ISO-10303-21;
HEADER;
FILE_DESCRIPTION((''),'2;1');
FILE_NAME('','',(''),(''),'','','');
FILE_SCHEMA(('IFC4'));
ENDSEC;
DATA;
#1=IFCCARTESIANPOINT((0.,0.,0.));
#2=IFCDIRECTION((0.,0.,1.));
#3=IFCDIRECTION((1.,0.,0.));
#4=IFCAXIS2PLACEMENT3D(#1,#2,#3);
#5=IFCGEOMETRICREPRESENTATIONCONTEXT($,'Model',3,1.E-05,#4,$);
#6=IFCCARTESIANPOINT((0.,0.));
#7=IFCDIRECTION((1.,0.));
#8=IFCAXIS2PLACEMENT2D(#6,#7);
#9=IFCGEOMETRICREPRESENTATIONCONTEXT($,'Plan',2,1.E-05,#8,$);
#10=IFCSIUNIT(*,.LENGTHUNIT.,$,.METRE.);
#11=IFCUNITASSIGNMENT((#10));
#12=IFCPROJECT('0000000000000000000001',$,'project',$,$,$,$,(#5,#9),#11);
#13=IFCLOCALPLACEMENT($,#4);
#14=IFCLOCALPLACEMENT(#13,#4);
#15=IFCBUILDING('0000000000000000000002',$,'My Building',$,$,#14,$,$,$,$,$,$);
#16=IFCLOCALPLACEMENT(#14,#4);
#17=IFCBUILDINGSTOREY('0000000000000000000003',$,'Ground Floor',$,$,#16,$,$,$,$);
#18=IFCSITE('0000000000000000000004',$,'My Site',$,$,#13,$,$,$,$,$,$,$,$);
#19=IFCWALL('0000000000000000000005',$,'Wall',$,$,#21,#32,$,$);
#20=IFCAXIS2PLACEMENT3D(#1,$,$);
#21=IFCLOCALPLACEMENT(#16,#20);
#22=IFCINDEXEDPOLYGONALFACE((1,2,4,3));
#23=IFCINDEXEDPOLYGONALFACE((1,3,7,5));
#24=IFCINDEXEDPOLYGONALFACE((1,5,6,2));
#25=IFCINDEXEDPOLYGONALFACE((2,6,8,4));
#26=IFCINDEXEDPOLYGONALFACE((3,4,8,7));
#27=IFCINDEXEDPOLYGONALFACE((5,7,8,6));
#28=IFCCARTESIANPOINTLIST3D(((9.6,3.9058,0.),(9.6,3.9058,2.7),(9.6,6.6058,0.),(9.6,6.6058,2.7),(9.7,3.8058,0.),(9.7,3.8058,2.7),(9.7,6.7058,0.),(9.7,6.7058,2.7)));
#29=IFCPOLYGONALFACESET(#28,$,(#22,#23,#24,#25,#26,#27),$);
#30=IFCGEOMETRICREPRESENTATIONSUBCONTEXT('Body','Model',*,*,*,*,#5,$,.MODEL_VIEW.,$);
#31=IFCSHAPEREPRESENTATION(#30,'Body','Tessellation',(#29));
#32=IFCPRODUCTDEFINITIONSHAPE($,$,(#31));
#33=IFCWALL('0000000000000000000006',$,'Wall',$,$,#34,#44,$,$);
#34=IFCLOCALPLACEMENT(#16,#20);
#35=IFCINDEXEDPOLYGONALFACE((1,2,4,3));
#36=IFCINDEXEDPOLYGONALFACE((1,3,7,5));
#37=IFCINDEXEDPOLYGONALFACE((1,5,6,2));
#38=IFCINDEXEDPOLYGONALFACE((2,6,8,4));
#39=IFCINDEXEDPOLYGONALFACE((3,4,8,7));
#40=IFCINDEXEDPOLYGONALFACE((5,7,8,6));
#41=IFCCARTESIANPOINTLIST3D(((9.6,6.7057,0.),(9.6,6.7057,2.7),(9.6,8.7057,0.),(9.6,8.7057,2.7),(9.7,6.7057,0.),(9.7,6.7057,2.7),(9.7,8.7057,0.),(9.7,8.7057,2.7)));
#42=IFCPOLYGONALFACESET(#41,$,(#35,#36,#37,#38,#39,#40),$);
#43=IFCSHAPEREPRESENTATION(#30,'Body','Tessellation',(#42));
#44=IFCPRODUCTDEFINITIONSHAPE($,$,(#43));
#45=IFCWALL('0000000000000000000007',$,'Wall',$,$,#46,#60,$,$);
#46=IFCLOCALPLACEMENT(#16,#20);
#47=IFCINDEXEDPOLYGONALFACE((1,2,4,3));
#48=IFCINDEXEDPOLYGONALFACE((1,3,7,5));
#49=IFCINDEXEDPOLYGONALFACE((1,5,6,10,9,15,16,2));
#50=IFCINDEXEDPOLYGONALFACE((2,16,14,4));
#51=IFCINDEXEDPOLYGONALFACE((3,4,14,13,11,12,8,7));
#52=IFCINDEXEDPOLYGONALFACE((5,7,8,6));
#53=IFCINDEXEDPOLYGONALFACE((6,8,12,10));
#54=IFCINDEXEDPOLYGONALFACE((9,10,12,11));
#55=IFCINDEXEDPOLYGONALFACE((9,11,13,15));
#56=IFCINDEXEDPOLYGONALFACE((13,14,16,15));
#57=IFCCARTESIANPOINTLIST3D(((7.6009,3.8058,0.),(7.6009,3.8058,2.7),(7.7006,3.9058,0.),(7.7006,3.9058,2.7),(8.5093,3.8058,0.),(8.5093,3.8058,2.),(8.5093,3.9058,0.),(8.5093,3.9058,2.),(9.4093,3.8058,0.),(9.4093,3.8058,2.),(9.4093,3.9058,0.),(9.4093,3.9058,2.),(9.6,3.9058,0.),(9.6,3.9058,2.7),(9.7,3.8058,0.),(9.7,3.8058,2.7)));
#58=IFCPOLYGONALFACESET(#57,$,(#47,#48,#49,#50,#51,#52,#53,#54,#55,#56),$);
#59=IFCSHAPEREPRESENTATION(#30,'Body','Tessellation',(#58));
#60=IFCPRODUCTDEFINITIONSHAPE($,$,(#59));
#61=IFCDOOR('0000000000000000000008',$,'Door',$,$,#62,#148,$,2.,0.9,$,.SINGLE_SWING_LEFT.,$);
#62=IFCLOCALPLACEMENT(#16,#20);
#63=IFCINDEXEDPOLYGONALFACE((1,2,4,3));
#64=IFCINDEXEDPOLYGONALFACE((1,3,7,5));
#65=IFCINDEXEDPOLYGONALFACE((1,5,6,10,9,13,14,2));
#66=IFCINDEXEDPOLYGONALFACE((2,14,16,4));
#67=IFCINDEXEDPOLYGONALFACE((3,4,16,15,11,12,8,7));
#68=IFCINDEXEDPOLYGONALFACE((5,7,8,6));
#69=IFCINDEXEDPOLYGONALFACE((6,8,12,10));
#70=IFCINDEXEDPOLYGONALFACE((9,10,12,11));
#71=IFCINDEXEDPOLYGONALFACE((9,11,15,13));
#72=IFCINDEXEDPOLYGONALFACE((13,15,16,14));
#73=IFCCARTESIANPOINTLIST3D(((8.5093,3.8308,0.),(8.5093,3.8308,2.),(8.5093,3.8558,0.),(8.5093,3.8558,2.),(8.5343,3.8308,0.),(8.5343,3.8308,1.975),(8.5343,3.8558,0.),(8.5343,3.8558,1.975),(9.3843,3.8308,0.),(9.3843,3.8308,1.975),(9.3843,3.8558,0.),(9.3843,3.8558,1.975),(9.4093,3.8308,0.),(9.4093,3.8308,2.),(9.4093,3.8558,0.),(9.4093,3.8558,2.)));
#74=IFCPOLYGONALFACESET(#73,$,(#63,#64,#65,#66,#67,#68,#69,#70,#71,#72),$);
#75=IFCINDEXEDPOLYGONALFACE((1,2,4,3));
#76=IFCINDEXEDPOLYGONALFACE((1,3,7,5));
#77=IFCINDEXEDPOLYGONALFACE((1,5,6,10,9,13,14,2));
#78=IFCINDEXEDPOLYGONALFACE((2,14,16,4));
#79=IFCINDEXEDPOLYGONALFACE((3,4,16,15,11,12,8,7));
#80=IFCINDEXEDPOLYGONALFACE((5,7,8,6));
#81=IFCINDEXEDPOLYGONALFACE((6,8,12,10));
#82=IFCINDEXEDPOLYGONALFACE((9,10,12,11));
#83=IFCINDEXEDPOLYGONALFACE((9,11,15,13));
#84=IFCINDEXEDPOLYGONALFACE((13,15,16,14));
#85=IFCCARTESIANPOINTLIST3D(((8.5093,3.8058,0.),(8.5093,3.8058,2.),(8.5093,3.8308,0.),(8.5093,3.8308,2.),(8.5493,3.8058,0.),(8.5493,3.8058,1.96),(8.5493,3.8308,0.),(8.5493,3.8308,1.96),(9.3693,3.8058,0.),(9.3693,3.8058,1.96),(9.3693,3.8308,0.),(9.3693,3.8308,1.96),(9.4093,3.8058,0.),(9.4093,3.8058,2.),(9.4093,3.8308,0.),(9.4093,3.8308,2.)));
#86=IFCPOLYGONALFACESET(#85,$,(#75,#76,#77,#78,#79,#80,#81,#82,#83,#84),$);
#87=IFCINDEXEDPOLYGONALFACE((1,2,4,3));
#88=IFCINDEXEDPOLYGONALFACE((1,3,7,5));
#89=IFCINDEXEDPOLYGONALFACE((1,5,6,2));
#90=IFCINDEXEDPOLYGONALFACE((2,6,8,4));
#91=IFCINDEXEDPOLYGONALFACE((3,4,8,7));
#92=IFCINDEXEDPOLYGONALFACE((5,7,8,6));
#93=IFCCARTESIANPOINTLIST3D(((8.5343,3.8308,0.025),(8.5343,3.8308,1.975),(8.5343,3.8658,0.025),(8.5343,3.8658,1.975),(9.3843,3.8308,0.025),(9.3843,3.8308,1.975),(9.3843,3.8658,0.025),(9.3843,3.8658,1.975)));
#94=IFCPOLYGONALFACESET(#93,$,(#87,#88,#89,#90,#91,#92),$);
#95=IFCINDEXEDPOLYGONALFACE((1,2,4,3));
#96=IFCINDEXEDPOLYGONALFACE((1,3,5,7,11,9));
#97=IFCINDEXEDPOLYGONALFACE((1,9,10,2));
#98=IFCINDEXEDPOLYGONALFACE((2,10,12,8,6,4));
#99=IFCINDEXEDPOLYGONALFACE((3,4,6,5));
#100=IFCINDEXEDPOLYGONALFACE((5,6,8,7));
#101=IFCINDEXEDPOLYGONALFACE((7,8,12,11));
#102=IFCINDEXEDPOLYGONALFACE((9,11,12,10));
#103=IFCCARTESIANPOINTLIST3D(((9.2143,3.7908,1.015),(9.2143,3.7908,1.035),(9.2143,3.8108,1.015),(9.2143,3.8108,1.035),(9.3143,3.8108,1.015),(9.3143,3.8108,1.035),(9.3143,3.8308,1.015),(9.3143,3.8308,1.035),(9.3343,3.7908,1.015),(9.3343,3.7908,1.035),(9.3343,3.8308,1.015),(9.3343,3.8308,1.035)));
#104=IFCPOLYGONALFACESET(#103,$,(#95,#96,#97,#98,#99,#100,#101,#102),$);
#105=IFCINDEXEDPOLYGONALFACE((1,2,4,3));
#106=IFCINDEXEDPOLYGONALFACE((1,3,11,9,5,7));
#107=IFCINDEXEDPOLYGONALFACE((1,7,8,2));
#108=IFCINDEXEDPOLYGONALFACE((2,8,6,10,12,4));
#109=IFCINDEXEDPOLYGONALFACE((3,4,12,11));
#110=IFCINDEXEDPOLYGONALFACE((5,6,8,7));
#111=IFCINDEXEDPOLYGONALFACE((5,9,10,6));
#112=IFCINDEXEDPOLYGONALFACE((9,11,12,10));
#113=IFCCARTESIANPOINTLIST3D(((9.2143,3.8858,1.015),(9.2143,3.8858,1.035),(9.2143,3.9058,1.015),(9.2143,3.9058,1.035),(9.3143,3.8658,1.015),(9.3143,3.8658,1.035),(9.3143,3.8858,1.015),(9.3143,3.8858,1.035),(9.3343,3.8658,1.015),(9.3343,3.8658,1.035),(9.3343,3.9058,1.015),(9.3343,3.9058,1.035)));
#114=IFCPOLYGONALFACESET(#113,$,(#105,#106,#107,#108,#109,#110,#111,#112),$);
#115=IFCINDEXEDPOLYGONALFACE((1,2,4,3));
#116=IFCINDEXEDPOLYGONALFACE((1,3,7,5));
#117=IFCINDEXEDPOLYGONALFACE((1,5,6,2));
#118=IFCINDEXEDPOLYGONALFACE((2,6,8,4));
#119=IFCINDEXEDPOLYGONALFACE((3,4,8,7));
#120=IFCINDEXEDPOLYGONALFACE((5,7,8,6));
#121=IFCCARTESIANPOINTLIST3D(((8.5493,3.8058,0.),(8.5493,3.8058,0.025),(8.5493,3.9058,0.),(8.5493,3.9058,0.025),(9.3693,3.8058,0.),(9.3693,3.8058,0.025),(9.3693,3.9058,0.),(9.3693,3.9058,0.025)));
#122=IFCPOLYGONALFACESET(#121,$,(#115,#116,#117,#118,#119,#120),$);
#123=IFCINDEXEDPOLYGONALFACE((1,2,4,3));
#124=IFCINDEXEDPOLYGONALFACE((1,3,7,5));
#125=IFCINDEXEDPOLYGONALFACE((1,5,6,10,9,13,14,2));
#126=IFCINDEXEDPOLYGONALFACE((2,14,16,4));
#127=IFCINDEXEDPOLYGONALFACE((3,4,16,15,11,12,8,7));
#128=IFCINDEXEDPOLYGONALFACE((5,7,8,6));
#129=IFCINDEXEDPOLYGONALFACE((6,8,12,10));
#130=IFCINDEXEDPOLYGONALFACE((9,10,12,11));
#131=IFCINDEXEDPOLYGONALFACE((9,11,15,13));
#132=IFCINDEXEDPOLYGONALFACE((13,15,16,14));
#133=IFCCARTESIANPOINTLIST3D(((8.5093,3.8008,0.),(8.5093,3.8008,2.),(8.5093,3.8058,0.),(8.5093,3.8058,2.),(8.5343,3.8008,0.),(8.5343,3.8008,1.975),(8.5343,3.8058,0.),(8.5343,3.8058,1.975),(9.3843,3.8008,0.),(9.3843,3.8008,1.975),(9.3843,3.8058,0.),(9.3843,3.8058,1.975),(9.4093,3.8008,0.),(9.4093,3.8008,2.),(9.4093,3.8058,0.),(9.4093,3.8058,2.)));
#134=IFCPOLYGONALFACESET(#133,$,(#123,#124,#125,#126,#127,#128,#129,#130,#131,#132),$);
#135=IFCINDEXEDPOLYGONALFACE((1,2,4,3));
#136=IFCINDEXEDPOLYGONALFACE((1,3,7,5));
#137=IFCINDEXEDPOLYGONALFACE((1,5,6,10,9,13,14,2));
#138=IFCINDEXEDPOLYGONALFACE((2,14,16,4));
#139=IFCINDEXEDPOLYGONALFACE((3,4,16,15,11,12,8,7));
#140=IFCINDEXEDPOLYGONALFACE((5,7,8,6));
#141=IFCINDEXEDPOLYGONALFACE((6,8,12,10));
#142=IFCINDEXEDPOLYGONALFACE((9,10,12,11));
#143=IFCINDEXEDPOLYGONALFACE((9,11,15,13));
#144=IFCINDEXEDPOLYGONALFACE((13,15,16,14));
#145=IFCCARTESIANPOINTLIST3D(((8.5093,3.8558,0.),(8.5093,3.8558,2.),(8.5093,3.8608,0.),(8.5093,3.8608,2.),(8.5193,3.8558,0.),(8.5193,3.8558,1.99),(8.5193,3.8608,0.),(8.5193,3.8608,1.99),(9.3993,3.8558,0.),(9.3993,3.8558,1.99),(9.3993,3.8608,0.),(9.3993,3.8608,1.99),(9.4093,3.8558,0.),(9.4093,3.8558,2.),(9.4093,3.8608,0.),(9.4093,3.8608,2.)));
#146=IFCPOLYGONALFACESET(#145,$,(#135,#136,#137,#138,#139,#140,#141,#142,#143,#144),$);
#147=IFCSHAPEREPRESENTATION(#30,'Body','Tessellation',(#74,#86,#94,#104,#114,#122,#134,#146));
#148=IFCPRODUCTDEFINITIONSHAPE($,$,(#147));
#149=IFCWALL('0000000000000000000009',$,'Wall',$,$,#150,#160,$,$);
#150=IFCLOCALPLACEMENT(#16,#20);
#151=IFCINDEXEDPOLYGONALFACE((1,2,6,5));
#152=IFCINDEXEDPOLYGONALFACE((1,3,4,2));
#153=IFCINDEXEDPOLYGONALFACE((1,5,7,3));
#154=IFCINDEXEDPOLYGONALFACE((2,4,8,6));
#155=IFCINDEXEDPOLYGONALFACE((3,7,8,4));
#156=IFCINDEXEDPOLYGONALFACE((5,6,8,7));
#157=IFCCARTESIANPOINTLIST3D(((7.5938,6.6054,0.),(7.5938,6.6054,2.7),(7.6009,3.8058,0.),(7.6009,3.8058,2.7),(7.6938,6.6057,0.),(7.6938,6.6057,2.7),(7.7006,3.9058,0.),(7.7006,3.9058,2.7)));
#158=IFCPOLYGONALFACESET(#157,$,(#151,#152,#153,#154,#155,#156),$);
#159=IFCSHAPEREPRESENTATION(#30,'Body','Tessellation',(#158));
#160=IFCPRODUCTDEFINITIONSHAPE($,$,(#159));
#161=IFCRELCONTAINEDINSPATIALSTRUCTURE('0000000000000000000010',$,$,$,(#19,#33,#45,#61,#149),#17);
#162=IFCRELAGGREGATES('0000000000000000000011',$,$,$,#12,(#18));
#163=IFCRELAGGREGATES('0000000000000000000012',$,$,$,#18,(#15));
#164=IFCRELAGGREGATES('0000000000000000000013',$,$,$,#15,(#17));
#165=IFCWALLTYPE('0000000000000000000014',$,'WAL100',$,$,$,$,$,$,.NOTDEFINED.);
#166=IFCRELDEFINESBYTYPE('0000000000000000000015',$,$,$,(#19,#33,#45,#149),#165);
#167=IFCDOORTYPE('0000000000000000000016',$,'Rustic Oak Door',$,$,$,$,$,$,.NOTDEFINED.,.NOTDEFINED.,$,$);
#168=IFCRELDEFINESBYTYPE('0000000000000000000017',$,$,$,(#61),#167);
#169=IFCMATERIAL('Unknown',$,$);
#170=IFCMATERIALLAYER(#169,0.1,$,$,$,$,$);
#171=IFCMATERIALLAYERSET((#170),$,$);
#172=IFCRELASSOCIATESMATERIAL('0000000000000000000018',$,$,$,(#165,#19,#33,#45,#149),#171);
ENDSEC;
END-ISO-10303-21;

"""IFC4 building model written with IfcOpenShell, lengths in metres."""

from ifc_helpers import new_model, entity, si_unit, frame, origin_with_axes, origin_2d_with_axis, place, context, subcontext, project, spatial, line, indexed_curve, outline, extrude, shape, source, transform, mapped, material, layer, layer_set, layer_usage, type_object, type_shapes, element, fill, save


model = new_model("IFC4")

# Units and contexts
model_context = context("Model", 3, precision=1e-05, world=origin_with_axes())
plan_context = context("Plan", 2, precision=1e-05, world=origin_2d_with_axis())
body_context_1 = subcontext(model_context, "Body", "Model", "MODEL_VIEW")
body_context_2 = subcontext(plan_context, "Body", "Plan", "PLAN_VIEW")
ifc_project = project(units=[si_unit("LENGTHUNIT", "METRE")], contexts=[model_context, plan_context])

# Site, building, storey
site_placement = place(None, origin_with_axes())
site = spatial("IfcSite", under=ifc_project, at=site_placement, Name="My Site")
building_placement = place(site_placement, origin_with_axes())
building = spatial("IfcBuilding", under=site, at=building_placement, Name="My Building")
storey_placement = place(building_placement, origin_with_axes())
storey = spatial("IfcBuildingStorey", under=building, at=storey_placement, Name="Ground Floor")

# Shared definitions
ifc_material = material(Name="Unknown")

# Shared definitions
ifc_layer_1 = layer(ifc_material, 0.1)
ifc_layer_set_1 = layer_set([ifc_layer_1])
wall_type = type_object("IfcWallType", Name="WAL100", PredefinedType="NOTDEFINED", material=ifc_layer_set_1)

# Shared definitions
shared_shape_1 = source(origin_with_axes(), body_context_1, "Body", "SweptSolid", [
    extrude(outline(indexed_curve([(0.0, 0.0), (0.9, 0.0), (0.9, 2.0), (0.0, 2.0)], segments=[line(1, 2, 3, 4, 1)])), frame((0.0, -0.6, 0.0), z_axis=(0.0, -1.0, 0.0), x_axis=(1.0, 0.0, 0.0)), (0.0, 0.0, -1.0), 1.2),
])
door_type_1 = type_object("IfcDoorType", Name="Rustic Oak Door", OperationType="NOTDEFINED", PredefinedType="NOTDEFINED")
shared_shape_2 = source(origin_with_axes(), body_context_1, "Body", "SweptSolid", [
    extrude(outline(indexed_curve([(0.0, 0.0), (0.0, 2.0), (0.9, 2.0), (0.9, 0.0), (0.875, 0.0), (0.875, 1.975), (0.025, 1.975), (0.025, 0.0)], segments=[line(1, 2, 3, 4, 5, 6, 7, 8, 1)])), frame((0.0, 0.025, 0.0), z_axis=(0.0, -1.0, 0.0), x_axis=(1.0, 0.0, 0.0)), (0.0, 0.0, -1.0), 0.025),
    extrude(outline(indexed_curve([(0.0, 0.0), (0.0, 2.0), (0.9, 2.0), (0.9, 0.0), (0.86, 0.0), (0.86, 1.96), (0.04, 1.96), (0.04, 0.0)], segments=[line(1, 2, 3, 4, 5, 6, 7, 8, 1)])), frame((0.0, 0.0, 0.0), z_axis=(0.0, -1.0, 0.0), x_axis=(1.0, 0.0, 0.0)), (0.0, 0.0, -1.0), 0.025),
    extrude(outline(indexed_curve([(0.0, 0.0), (0.85, 0.0), (0.85, 0.035), (0.0, 0.035)], segments=[line(1, 2, 3, 4, 1)])), frame((0.025, 0.025, 0.025), z_axis=(0.0, 0.0, 1.0), x_axis=(1.0, 0.0, 0.0)), (0.0, 0.0, 1.0), 1.95),
    extrude(outline(indexed_curve([(0.0, 0.0), (0.0, -0.04), (-0.12, -0.04), (-0.12, -0.02), (-0.02, -0.02), (-0.02, 0.0)], segments=[line(1, 2, 3, 4, 5, 6, 1)])), frame((0.825, 0.025, 1.015), z_axis=(0.0, 0.0, 1.0), x_axis=(1.0, 0.0, 0.0)), (0.0, 0.0, 1.0), 0.02),
    extrude(outline(indexed_curve([(0.0, 0.0), (0.0, 0.04), (-0.12, 0.04), (-0.12, 0.02), (-0.02, 0.02), (-0.02, 0.0)], segments=[line(1, 2, 3, 4, 5, 6, 1)])), frame((0.825, 0.06, 1.015), z_axis=(0.0, 0.0, 1.0), x_axis=(1.0, 0.0, 0.0)), (0.0, 0.0, 1.0), 0.02),
    extrude(outline(indexed_curve([(0.0, 0.0), (0.82, 0.0), (0.82, 0.1), (0.0, 0.1)], segments=[line(1, 2, 3, 4, 1)])), frame((0.04, 0.0, 0.0), z_axis=(0.0, 0.0, 1.0), x_axis=(1.0, 0.0, 0.0)), (0.0, 0.0, 1.0), 0.025),
    extrude(outline(indexed_curve([(0.0, 0.0), (0.0, 2.0), (0.9, 2.0), (0.9, 0.0), (0.875, 0.0), (0.875, 1.975), (0.025, 1.975), (0.025, 0.0)], segments=[line(1, 2, 3, 4, 5, 6, 7, 8, 1)])), frame((0.0, -0.005, 0.0), z_axis=(0.0, -1.0, 0.0), x_axis=(1.0, 0.0, 0.0)), (0.0, 0.0, -1.0), 0.005),
    extrude(outline(indexed_curve([(0.0, 0.0), (0.0, 2.0), (0.9, 2.0), (0.9, 0.0), (0.89, 0.0), (0.89, 1.99), (0.01, 1.99), (0.01, 0.0)], segments=[line(1, 2, 3, 4, 5, 6, 7, 8, 1)])), frame((0.0, 0.05, 0.0), z_axis=(0.0, -1.0, 0.0), x_axis=(1.0, 0.0, 0.0)), (0.0, 0.0, -1.0), 0.005),
])
shared_shape_3 = source(origin_with_axes(), body_context_2, "Body", "Curve2D", [
    entity("IfcIndexedPolyCurve", entity("IfcCartesianPointList2D", [[0.0, 0.0], [0.0, 0.05], [0.025, 0.05], [0.025, 0.025], [0.04, 0.025], [0.04, 0.0]]), [entity("IfcLineIndex", [1, 2, 3, 4, 5, 6, 1])]),
    entity("IfcIndexedPolyCurve", entity("IfcCartesianPointList2D", [[0.9, 0.0], [0.9, 0.05], [0.875, 0.05], [0.875, 0.025], [0.86, 0.025], [0.86, 0.0]]), [entity("IfcLineIndex", [1, 2, 3, 4, 5, 6, 1])]),
    entity("IfcTrimmedCurve", entity("IfcEllipse", entity("IfcAxis2Placement2D", entity("IfcCartesianPoint", [0.06, 0.05]), entity("IfcDirection", [1.0, 0.0])), 0.815, 0.85), [entity("IfcCartesianPoint", [0.875, 0.05])], [entity("IfcCartesianPoint", [0.06, 0.9])], True, "CARTESIAN"),
    entity("IfcIndexedPolyCurve", entity("IfcCartesianPointList2D", [[0.025, 0.05], [0.06, 0.05], [0.06, 0.9], [0.025, 0.9]]), [entity("IfcLineIndex", [1, 2, 3, 4, 1])]),
])
type_shapes(door_type_1, [shared_shape_2, shared_shape_3])

# Walls
ifc_layer_usage_1 = layer_usage(ifc_layer_set_1, "AXIS2", "POSITIVE", 0.0)
wall_1_placement = place(storey_placement, frame((9.6, 6.6058, 0.0), z_axis=(0.0, 0.0, 1.0), x_axis=(0.0, -1.0, 0.0)))
element("IfcWall", 1, at=wall_1_placement, inside=storey, type_object=wall_type, material=ifc_layer_usage_1, Name="Wall", context=body_context_1, shape_type="SweptSolid", body=[
    extrude(outline(indexed_curve([(0.0, 0.0), (-0.1, 0.1), (2.8, 0.1), (2.7, 0.0)], segments=[line(1, 2, 3, 4, 1)])), origin_with_axes(), (0.0, 0.0, 1.0), 2.7),
])
ifc_layer_usage_2 = layer_usage(ifc_layer_set_1, "AXIS2", "POSITIVE", 0.0)
wall_2_placement = place(storey_placement, frame((9.6, 8.7057, 0.0), z_axis=(0.0, 0.0, 1.0), x_axis=(0.0, -1.0, 0.0)))
element("IfcWall", 2, at=wall_2_placement, inside=storey, type_object=wall_type, material=ifc_layer_usage_2, Name="Wall", context=body_context_1, shape_type="SweptSolid", body=[
    extrude(outline(indexed_curve([(0.0, 0.0), (0.0, 0.1), (2.0, 0.1), (2.0, 0.0)], segments=[line(1, 2, 3, 4, 1)])), origin_with_axes(), (0.0, 0.0, 1.0), 2.7),
])

# Wall, opening, door
ifc_layer_usage_3 = layer_usage(ifc_layer_set_1, "AXIS2", "POSITIVE", 0.0)
wall_3_placement = place(storey_placement, frame((9.6, 3.9058, 0.0), z_axis=(0.0, 0.0, 1.0), x_axis=(-1.0, 0.0, 0.0)))
wall_3 = element("IfcWall", 3, at=wall_3_placement, inside=storey, type_object=wall_type, material=ifc_layer_usage_3, Name="Wall", context=body_context_1, shape_type="SweptSolid", body=[
    extrude(outline(indexed_curve([(0.0, 0.0), (-0.1, 0.1), (1.9991, 0.1), (1.8994, 0.0)], segments=[line(1, 2, 3, 4, 1)])), origin_with_axes(), (0.0, 0.0, 1.0), 2.7),
])
opening_1_placement = place(wall_3_placement, frame((1.0907, 0.1, 0.0), z_axis=(0.0, 0.0, 1.0), x_axis=(-1.0, 0.0, 0.0)))
opening_1 = element("IfcOpeningElement", 4, at=opening_1_placement, cuts=wall_3, PredefinedType="OPENING", context=body_context_1, shape_type="MappedRepresentation", body=[
    mapped(shared_shape_1, transform((0.0, 0.0, 0.0), x_axis=(1.0, 0.0, 0.0), y_axis=(0.0, 1.0, 0.0), z_axis=(0.0, 0.0, 1.0), scale=1.0)),
])
door_1_placement = place(opening_1_placement, frame((0.0, 0.0, 0.0), z_axis=(0.0, 0.0, 1.0), x_axis=(1.0, 0.0, 0.0)))
door_1 = element("IfcDoor", 5, at=door_1_placement, inside=storey, type_object=door_type_1, Name="Door", OperationType="SINGLE_SWING_LEFT", OverallHeight=2.0, OverallWidth=0.9, shapes=[
    shape(body_context_1, "Body", "MappedRepresentation", [mapped(shared_shape_2, transform((0.0, 0.0, 0.0), x_axis=(1.0, 0.0, 0.0), y_axis=(0.0, 1.0, 0.0), z_axis=(0.0, 0.0, 1.0), scale=1.0))]),
    shape(body_context_2, "Body", "MappedRepresentation", [mapped(shared_shape_3, transform((0.0, 0.0, 0.0), x_axis=(1.0, 0.0, 0.0), y_axis=(0.0, 1.0, 0.0), z_axis=(0.0, 0.0, 1.0), scale=1.0))]),
])
fill(opening_1, door_1)

# Wall
ifc_layer_usage_4 = layer_usage(ifc_layer_set_1, "AXIS2", "POSITIVE", 0.0)
wall_4_placement = place(storey_placement, frame((7.7006, 3.9058, 0.0), z_axis=(0.0, 0.0, 1.0), x_axis=(-0.002547, 0.999997, 0.0)))
element("IfcWall", 6, at=wall_4_placement, inside=storey, type_object=wall_type, material=ifc_layer_usage_4, Name="Wall", context=body_context_1, shape_type="SweptSolid", body=[
    extrude(outline(indexed_curve([(0.0, 0.0), (-0.0997, 0.1), (2.6998, 0.1), (2.6998, 0.0)], segments=[line(1, 2, 3, 4, 1)])), origin_with_axes(), (0.0, 0.0, 1.0), 2.7),
])

save(model, "model.ifc")
